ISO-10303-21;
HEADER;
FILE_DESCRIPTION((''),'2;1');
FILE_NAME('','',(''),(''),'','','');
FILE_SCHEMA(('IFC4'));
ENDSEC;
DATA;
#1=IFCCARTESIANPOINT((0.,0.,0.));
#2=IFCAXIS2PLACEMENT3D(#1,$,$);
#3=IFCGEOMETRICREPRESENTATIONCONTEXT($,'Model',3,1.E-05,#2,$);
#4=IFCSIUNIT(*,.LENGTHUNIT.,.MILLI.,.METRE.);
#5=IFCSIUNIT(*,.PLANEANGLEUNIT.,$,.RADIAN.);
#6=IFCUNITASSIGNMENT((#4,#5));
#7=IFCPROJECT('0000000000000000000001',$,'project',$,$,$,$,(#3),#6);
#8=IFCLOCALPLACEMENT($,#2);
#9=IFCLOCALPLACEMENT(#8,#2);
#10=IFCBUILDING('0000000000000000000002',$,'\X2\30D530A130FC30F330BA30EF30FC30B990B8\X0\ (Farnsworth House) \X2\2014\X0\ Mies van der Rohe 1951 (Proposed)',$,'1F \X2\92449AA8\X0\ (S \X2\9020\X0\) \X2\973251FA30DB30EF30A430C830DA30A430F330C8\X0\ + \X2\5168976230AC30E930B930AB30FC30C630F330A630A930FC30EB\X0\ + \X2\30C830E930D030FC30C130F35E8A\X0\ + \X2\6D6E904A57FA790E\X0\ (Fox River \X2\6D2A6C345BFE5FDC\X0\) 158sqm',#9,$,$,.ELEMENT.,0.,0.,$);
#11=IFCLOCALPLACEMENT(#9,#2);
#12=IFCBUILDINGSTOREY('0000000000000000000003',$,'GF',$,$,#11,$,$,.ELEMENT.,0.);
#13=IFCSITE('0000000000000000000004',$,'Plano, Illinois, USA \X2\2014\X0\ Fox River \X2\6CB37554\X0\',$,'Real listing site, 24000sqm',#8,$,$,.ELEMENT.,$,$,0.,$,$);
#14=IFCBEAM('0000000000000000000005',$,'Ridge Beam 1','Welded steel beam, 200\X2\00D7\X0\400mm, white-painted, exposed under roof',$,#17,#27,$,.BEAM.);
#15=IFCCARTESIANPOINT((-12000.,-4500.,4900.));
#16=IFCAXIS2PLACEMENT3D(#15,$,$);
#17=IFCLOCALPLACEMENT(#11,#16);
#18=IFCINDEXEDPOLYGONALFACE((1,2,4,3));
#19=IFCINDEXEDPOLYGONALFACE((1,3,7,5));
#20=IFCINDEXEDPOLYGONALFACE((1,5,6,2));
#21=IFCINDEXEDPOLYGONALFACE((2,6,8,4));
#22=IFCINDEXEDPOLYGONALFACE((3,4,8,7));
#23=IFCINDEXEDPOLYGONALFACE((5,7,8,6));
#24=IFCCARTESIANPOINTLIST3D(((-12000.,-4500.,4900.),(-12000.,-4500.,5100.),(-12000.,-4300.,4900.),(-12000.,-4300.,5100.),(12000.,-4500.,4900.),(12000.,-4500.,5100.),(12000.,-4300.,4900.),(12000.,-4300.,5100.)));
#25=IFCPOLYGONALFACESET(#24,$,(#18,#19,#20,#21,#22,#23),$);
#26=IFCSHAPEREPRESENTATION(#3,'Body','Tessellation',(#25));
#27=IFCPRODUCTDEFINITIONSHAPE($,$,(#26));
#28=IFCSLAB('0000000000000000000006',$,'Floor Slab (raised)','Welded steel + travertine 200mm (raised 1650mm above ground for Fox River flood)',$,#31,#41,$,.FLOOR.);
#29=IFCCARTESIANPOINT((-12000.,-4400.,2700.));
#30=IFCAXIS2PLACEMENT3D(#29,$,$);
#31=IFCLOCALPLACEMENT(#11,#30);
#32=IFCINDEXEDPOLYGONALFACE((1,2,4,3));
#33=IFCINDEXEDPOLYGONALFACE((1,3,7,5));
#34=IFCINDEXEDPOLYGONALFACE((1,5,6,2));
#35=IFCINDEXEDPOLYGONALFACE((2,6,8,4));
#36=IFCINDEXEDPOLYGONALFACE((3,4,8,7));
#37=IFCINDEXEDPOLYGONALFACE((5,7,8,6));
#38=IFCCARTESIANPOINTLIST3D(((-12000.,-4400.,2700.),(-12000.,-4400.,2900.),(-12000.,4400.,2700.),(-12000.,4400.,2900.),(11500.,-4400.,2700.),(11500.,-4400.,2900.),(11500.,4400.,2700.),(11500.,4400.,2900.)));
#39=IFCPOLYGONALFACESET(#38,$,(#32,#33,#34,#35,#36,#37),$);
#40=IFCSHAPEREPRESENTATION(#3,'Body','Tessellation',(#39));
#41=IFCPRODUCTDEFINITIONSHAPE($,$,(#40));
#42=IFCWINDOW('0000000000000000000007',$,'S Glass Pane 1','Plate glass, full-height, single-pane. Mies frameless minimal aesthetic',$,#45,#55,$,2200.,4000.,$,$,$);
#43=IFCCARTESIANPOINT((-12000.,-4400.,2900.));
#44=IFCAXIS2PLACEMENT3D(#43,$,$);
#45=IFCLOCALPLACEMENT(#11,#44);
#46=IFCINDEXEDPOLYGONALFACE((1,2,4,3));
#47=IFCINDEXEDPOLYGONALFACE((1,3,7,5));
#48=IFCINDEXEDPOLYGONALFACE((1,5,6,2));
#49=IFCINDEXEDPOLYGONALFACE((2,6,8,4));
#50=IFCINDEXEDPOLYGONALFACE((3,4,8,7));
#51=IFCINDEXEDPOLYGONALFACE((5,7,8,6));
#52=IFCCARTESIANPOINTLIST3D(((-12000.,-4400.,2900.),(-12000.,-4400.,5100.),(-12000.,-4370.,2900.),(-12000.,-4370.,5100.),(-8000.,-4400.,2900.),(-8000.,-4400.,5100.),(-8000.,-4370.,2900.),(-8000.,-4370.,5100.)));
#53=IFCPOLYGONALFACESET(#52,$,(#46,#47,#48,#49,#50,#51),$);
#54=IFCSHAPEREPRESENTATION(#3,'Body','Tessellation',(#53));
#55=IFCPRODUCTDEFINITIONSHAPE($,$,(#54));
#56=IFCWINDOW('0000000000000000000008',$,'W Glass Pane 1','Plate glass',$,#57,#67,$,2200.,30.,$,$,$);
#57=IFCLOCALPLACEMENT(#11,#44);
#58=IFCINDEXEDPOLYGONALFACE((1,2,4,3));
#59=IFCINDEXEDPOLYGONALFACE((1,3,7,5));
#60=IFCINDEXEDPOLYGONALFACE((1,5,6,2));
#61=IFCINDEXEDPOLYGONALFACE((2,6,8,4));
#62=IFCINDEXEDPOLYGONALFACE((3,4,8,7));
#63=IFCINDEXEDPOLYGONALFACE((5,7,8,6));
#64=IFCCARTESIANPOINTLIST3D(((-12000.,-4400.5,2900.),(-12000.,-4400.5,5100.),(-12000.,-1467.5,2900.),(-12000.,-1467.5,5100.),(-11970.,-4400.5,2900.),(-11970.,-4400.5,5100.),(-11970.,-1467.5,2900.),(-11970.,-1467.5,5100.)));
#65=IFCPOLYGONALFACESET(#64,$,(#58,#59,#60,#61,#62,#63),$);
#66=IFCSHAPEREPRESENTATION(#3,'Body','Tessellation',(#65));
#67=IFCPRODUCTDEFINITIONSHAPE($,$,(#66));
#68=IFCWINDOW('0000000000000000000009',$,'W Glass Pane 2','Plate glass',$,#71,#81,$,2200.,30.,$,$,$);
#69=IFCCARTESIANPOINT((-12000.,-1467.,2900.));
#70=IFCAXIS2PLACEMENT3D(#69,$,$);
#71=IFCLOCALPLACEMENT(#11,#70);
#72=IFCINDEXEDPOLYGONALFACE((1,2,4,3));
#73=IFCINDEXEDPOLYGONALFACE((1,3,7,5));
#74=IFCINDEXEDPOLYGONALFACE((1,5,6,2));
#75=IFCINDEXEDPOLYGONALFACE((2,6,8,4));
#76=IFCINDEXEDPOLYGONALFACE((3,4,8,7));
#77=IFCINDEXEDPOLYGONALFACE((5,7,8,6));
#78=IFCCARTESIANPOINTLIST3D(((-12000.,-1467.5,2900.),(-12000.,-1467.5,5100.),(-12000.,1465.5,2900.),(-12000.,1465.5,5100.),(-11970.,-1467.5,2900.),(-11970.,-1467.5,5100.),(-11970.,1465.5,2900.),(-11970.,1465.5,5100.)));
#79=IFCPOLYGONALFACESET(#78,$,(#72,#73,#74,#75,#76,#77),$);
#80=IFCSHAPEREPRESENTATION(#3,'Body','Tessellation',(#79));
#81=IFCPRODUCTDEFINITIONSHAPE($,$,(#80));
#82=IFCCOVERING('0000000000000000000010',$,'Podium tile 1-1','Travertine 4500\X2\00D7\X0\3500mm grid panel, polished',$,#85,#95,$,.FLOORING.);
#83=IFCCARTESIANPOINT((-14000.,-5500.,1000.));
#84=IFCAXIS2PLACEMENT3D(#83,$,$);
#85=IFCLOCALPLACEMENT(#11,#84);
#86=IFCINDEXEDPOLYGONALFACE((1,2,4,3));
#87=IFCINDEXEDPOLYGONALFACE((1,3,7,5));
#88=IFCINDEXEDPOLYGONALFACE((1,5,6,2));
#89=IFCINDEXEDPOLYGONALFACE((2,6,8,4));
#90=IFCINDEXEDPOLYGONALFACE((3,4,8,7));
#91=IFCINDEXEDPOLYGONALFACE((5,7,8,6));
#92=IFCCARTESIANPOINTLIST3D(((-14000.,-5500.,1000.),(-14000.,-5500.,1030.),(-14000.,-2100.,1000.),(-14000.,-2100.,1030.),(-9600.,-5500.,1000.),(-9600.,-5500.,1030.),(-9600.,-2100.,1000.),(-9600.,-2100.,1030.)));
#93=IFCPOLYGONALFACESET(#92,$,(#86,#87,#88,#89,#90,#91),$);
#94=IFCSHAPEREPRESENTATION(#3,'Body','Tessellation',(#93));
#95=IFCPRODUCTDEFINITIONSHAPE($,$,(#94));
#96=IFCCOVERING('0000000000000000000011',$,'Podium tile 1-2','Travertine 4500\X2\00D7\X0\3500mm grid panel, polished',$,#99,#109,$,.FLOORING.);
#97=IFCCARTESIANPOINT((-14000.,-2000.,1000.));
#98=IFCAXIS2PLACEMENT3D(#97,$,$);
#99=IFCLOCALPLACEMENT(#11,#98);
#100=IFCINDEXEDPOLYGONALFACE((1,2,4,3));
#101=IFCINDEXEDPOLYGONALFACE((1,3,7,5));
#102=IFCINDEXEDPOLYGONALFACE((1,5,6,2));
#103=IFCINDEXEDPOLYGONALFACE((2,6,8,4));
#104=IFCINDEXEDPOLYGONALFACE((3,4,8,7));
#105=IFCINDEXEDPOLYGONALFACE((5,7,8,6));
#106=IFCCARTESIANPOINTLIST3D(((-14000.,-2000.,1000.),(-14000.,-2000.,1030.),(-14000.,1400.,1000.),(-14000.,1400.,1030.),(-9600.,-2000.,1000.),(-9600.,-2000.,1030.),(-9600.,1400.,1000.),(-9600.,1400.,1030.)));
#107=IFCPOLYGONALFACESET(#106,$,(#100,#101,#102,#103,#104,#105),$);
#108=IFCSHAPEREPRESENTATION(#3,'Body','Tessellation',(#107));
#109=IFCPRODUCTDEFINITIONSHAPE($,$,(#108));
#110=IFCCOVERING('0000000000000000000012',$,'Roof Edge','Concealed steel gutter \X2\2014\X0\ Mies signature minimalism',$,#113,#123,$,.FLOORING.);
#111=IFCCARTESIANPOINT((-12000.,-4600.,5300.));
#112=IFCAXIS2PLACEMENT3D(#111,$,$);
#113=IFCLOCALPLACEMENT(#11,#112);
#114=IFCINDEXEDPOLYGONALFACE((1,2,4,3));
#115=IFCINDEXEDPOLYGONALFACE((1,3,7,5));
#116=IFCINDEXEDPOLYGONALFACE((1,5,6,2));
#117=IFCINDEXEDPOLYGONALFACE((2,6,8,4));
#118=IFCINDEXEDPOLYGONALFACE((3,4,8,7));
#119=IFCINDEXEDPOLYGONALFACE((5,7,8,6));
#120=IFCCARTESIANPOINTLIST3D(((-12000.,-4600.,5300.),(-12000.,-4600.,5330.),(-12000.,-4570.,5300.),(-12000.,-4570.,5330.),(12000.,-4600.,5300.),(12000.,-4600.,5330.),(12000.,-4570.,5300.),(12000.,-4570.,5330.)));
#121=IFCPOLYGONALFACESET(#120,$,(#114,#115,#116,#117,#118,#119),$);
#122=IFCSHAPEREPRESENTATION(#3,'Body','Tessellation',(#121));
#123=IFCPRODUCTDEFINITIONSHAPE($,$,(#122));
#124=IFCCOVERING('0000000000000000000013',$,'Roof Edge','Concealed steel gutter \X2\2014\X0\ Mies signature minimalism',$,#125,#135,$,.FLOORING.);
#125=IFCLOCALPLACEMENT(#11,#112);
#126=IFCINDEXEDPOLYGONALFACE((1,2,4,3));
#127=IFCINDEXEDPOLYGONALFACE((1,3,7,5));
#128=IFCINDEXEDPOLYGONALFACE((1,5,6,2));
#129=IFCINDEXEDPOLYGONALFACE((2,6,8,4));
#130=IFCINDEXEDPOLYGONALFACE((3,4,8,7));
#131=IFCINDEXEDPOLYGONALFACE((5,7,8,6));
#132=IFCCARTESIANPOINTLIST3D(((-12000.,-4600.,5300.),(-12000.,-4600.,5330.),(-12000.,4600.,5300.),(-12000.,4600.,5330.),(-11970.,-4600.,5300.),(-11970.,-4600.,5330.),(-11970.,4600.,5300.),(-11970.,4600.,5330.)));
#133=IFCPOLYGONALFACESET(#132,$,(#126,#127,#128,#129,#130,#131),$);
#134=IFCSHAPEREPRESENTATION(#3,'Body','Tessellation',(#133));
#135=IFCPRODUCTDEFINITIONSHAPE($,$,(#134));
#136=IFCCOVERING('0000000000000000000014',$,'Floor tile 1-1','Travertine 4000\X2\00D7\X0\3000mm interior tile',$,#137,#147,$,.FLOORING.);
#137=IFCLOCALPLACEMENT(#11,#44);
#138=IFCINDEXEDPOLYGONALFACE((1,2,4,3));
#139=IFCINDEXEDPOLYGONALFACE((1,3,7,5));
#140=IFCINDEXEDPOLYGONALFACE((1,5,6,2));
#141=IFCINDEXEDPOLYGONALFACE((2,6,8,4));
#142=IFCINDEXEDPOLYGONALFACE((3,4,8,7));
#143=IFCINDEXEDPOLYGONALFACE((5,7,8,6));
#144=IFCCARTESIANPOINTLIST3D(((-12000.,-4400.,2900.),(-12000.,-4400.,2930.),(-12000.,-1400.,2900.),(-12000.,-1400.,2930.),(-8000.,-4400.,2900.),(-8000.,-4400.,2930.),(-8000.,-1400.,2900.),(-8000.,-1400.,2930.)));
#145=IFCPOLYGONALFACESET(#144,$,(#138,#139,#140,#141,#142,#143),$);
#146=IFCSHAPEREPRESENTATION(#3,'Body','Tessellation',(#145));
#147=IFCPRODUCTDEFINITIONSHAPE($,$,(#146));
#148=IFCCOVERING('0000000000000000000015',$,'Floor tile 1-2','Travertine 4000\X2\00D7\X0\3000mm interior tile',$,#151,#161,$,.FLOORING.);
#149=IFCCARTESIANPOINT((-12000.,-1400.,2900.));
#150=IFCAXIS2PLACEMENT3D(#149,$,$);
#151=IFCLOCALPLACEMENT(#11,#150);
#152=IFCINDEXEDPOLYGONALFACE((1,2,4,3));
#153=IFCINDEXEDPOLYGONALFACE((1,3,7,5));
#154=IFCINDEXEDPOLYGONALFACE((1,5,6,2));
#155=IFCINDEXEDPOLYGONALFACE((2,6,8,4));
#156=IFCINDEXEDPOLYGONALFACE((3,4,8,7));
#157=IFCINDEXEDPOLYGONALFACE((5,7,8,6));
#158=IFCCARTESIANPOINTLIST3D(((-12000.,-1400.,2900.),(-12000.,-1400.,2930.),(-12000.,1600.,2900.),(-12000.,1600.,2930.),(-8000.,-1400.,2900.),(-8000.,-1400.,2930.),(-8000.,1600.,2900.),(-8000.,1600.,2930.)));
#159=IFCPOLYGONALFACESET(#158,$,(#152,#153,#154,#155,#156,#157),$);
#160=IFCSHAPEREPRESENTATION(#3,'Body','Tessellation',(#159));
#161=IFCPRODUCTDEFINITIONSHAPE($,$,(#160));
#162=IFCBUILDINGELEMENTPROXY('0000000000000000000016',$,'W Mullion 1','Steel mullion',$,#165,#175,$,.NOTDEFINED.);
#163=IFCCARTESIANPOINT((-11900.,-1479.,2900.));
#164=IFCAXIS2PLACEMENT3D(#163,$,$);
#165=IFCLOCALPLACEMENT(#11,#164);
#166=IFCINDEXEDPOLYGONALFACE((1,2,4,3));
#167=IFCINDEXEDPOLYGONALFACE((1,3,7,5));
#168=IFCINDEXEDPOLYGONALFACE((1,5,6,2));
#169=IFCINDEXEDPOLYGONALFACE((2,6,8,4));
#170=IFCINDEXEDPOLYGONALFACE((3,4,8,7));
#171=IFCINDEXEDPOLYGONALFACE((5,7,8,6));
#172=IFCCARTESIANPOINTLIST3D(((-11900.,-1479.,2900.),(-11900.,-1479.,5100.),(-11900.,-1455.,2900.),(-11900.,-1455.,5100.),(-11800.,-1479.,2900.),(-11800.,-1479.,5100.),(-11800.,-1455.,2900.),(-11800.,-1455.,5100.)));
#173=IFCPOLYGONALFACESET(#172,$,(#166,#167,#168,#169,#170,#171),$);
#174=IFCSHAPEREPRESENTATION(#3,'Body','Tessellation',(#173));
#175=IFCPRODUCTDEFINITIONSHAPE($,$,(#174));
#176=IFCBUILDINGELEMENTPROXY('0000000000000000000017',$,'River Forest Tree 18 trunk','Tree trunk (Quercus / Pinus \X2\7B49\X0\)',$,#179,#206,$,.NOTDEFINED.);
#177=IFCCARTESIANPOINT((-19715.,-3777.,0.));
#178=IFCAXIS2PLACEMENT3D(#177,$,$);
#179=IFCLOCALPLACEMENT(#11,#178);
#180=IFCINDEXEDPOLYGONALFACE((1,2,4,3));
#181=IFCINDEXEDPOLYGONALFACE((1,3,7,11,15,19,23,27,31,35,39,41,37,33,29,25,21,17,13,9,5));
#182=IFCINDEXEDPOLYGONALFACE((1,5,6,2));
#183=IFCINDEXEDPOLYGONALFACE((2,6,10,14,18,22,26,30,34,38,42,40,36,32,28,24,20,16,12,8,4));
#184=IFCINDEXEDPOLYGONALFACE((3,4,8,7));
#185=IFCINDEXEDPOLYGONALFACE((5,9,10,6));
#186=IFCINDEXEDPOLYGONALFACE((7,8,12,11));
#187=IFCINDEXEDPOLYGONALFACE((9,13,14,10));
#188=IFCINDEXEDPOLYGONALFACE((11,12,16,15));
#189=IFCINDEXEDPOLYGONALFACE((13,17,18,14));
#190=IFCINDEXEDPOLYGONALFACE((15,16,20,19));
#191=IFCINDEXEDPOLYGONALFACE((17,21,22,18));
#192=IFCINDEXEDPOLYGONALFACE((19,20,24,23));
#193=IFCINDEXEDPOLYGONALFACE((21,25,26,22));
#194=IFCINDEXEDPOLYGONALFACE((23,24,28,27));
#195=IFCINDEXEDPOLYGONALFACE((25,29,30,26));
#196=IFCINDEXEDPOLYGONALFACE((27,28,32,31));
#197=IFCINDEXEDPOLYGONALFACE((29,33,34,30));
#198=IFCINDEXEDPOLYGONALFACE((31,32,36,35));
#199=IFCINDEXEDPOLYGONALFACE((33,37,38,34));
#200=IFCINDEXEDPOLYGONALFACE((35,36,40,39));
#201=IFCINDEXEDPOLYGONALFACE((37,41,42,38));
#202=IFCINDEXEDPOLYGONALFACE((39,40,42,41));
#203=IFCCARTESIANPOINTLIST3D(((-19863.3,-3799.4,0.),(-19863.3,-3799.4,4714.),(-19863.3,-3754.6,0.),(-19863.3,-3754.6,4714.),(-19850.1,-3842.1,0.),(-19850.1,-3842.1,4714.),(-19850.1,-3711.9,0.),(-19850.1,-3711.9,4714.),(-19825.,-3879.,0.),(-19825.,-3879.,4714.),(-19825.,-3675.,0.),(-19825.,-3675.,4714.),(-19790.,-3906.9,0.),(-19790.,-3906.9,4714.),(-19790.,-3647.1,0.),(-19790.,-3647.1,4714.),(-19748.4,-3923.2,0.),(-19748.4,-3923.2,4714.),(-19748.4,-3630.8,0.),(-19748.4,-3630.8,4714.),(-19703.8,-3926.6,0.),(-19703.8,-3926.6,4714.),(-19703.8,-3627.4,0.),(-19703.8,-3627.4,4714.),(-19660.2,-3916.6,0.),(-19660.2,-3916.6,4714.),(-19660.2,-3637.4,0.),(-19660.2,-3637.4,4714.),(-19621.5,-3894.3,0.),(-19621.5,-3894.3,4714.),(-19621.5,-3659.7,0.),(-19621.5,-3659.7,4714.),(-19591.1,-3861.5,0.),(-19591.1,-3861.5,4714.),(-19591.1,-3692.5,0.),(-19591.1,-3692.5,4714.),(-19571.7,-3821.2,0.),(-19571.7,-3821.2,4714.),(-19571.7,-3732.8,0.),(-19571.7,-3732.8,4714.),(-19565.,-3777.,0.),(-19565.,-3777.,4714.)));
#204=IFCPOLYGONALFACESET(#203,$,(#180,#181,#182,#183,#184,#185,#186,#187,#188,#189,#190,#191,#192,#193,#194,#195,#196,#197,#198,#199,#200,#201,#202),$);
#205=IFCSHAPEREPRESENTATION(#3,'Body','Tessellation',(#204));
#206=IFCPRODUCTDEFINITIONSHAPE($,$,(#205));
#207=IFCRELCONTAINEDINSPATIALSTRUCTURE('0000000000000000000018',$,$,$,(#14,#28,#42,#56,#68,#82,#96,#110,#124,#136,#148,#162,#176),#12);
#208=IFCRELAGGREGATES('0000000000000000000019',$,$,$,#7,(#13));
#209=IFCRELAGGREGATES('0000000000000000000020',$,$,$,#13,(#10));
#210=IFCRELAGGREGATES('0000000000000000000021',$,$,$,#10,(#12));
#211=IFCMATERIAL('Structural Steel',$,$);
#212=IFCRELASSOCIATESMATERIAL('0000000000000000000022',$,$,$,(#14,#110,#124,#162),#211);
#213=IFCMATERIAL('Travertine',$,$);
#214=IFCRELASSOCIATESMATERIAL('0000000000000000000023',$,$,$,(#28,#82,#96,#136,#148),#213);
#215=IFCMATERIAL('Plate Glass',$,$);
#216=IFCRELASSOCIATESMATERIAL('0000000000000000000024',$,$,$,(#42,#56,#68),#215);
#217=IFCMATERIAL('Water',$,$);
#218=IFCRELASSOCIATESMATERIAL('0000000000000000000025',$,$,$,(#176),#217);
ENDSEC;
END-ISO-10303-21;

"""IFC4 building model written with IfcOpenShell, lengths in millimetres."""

from ifc_helpers import new_model, si_unit, frame, frame_2d, origin, origin_2d, place, context, project, spatial, rectangle, circle, extrude, material, element, save


model = new_model("IFC4")

# Units and contexts
model_context = context("Model", 3, precision=1e-05, world=origin())
ifc_project = project(units=[si_unit("LENGTHUNIT", "METRE", prefix="MILLI"), si_unit("PLANEANGLEUNIT", "RADIAN")], contexts=[model_context])

# Site, building, storey
site_placement = place(None, origin())
site = spatial("IfcSite", under=ifc_project, at=site_placement, Name="Plano, Illinois, USA — Fox River 河畔", ObjectType="Real listing site, 24000sqm", CompositionType="ELEMENT", RefElevation=0.0)
building_placement = place(site_placement, origin())
building = spatial("IfcBuilding", under=site, at=building_placement, Name="ファーンズワース邸 (Farnsworth House) — Mies van der Rohe 1951 (Proposed)", ObjectType="1F 鉄骨 (S 造) 露出ホワイトペイント + 全面ガラスカーテンウォール + トラバーチン床 + 浮遊基礎 (Fox River 洪水対応) 158sqm", CompositionType="ELEMENT", ElevationOfRefHeight=0.0, ElevationOfTerrain=0.0)
storey_placement = place(building_placement, origin())
storey = spatial("IfcBuildingStorey", under=building, at=storey_placement, Name="GF", CompositionType="ELEMENT", Elevation=0.0)

# Beam
ifc_material_1 = material(Name="Structural Steel")
beam_placement = place(storey_placement, frame((-12000.0, -4500.0, 4900.0)))
element("IfcBeam", 1, at=beam_placement, inside=storey, material=ifc_material_1, Name="Ridge Beam 1", Description="Welded steel beam, 200×400mm, white-painted, exposed under roof", PredefinedType="BEAM", context=model_context, shape_type="SweptSolid", body=[
    extrude(rectangle(XDim=24000.0, YDim=200.0, at=frame_2d((12000.0, 100.0))), frame((-12000.0, -4500.0, 4900.0)), (0.0, 0.0, 1.0), 200.0),
])

# Slab
ifc_material_2 = material(Name="Travertine")
slab_1_placement = place(storey_placement, frame((-12000.0, -4400.0, 2700.0)))
element("IfcSlab", 2, at=slab_1_placement, inside=storey, material=ifc_material_2, Name="Floor Slab (raised)", Description="Welded steel + travertine 200mm (raised 1650mm above ground for Fox River flood)", PredefinedType="FLOOR", context=model_context, shape_type="SweptSolid", body=[
    extrude(rectangle(XDim=23500.0, YDim=8800.0, at=frame_2d((11750.0, 4400.0))), frame((-12000.0, -4400.0, 2700.0)), (0.0, 0.0, 1.0), 200.0),
])

# Windows
ifc_material_3 = material(Name="Plate Glass")
window_1_placement = place(storey_placement, frame((-12000.0, -4400.0, 2900.0)))
element("IfcWindow", 3, at=window_1_placement, inside=storey, material=ifc_material_3, Name="S Glass Pane 1", Description="Plate glass, full-height, single-pane. Mies frameless minimal aesthetic", OverallHeight=2200.0, OverallWidth=4000.0, context=model_context, shape_type="SweptSolid", body=[
    extrude(rectangle(XDim=4000.0, YDim=30.0, at=frame_2d((2000.0, 15.0))), frame((-12000.0, -4400.0, 2900.0)), (0.0, 0.0, 1.0), 2200.0),
])
window_2_placement = place(storey_placement, frame((-12000.0, -4400.0, 2900.0)))
element("IfcWindow", 4, at=window_2_placement, inside=storey, material=ifc_material_3, Name="W Glass Pane 1", Description="Plate glass", OverallHeight=2200.0, OverallWidth=30.0, context=model_context, shape_type="SweptSolid", body=[
    extrude(rectangle(XDim=30.0, YDim=2933.0, at=frame_2d((15.0, 1466.0))), frame((-12000.0, -4400.0, 2900.0)), (0.0, 0.0, 1.0), 2200.0),
])
window_3_placement = place(storey_placement, frame((-12000.0, -1467.0, 2900.0)))
element("IfcWindow", 5, at=window_3_placement, inside=storey, material=ifc_material_3, Name="W Glass Pane 2", Description="Plate glass", OverallHeight=2200.0, OverallWidth=30.0, context=model_context, shape_type="SweptSolid", body=[
    extrude(rectangle(XDim=30.0, YDim=2933.0, at=frame_2d((15.0, 1466.0))), frame((-12000.0, -1467.0, 2900.0)), (0.0, 0.0, 1.0), 2200.0),
])

# Coverings
covering_1_placement = place(storey_placement, frame((-14000.0, -5500.0, 1000.0)))
element("IfcCovering", 6, at=covering_1_placement, inside=storey, material=ifc_material_2, Name="Podium tile 1-1", Description="Travertine 4500×3500mm grid panel, polished", PredefinedType="FLOORING", context=model_context, shape_type="SweptSolid", body=[
    extrude(rectangle(XDim=4400.0, YDim=3400.0, at=frame_2d((2200.0, 1700.0))), frame((-14000.0, -5500.0, 1000.0)), (0.0, 0.0, 1.0), 30.0),
])
covering_2_placement = place(storey_placement, frame((-14000.0, -2000.0, 1000.0)))
element("IfcCovering", 7, at=covering_2_placement, inside=storey, material=ifc_material_2, Name="Podium tile 1-2", Description="Travertine 4500×3500mm grid panel, polished", PredefinedType="FLOORING", context=model_context, shape_type="SweptSolid", body=[
    extrude(rectangle(XDim=4400.0, YDim=3400.0, at=frame_2d((2200.0, 1700.0))), frame((-14000.0, -2000.0, 1000.0)), (0.0, 0.0, 1.0), 30.0),
])
covering_3_placement = place(storey_placement, frame((-12000.0, -4600.0, 5300.0)))
element("IfcCovering", 8, at=covering_3_placement, inside=storey, material=ifc_material_1, Name="Roof Edge", Description="Concealed steel gutter — Mies signature minimalism", PredefinedType="FLOORING", context=model_context, shape_type="SweptSolid", body=[
    extrude(rectangle(XDim=24000.0, YDim=30.0, at=frame_2d((12000.0, 15.0))), frame((-12000.0, -4600.0, 5300.0)), (0.0, 0.0, 1.0), 30.0),
])
covering_4_placement = place(storey_placement, frame((-12000.0, -4600.0, 5300.0)))
element("IfcCovering", 9, at=covering_4_placement, inside=storey, material=ifc_material_1, Name="Roof Edge", Description="Concealed steel gutter — Mies signature minimalism", PredefinedType="FLOORING", context=model_context, shape_type="SweptSolid", body=[
    extrude(rectangle(XDim=30.0, YDim=9200.0, at=frame_2d((15.0, 4600.0))), frame((-12000.0, -4600.0, 5300.0)), (0.0, 0.0, 1.0), 30.0),
])
covering_5_placement = place(storey_placement, frame((-12000.0, -4400.0, 2900.0)))
element("IfcCovering", 10, at=covering_5_placement, inside=storey, material=ifc_material_2, Name="Floor tile 1-1", Description="Travertine 4000×3000mm interior tile", PredefinedType="FLOORING", context=model_context, shape_type="SweptSolid", body=[
    extrude(rectangle(XDim=4000.0, YDim=3000.0, at=frame_2d((2000.0, 1500.0))), frame((-12000.0, -4400.0, 2900.0)), (0.0, 0.0, 1.0), 30.0),
])
covering_6_placement = place(storey_placement, frame((-12000.0, -1400.0, 2900.0)))
element("IfcCovering", 11, at=covering_6_placement, inside=storey, material=ifc_material_2, Name="Floor tile 1-2", Description="Travertine 4000×3000mm interior tile", PredefinedType="FLOORING", context=model_context, shape_type="SweptSolid", body=[
    extrude(rectangle(XDim=4000.0, YDim=3000.0, at=frame_2d((2000.0, 1500.0))), frame((-12000.0, -1400.0, 2900.0)), (0.0, 0.0, 1.0), 30.0),
])

# Building element proxies
proxy_1_placement = place(storey_placement, frame((-11900.0, -1479.0, 2900.0)))
element("IfcBuildingElementProxy", 12, at=proxy_1_placement, inside=storey, material=ifc_material_1, Name="W Mullion 1", Description="Steel mullion", PredefinedType="NOTDEFINED", context=model_context, shape_type="SweptSolid", body=[
    extrude(rectangle(XDim=100.0, YDim=24.0, at=frame_2d((50.0, 12.0))), frame((-11900.0, -1479.0, 2900.0)), (0.0, 0.0, 1.0), 2200.0),
])
ifc_material_4 = material(Name="Water")
proxy_2_placement = place(storey_placement, frame((-19715.0, -3777.0, 0.0)))
element("IfcBuildingElementProxy", 13, at=proxy_2_placement, inside=storey, material=ifc_material_4, Name="River Forest Tree 18 trunk", Description="Tree trunk (Quercus / Pinus 等)", PredefinedType="NOTDEFINED", context=model_context, shape_type="SweptSolid", body=[
    extrude(circle(Radius=150.0, at=origin_2d()), frame((-19715.0, -3777.0, 0.0)), (0.0, 0.0, 1.0), 4714.0),
])

save(model, "model.ifc")
